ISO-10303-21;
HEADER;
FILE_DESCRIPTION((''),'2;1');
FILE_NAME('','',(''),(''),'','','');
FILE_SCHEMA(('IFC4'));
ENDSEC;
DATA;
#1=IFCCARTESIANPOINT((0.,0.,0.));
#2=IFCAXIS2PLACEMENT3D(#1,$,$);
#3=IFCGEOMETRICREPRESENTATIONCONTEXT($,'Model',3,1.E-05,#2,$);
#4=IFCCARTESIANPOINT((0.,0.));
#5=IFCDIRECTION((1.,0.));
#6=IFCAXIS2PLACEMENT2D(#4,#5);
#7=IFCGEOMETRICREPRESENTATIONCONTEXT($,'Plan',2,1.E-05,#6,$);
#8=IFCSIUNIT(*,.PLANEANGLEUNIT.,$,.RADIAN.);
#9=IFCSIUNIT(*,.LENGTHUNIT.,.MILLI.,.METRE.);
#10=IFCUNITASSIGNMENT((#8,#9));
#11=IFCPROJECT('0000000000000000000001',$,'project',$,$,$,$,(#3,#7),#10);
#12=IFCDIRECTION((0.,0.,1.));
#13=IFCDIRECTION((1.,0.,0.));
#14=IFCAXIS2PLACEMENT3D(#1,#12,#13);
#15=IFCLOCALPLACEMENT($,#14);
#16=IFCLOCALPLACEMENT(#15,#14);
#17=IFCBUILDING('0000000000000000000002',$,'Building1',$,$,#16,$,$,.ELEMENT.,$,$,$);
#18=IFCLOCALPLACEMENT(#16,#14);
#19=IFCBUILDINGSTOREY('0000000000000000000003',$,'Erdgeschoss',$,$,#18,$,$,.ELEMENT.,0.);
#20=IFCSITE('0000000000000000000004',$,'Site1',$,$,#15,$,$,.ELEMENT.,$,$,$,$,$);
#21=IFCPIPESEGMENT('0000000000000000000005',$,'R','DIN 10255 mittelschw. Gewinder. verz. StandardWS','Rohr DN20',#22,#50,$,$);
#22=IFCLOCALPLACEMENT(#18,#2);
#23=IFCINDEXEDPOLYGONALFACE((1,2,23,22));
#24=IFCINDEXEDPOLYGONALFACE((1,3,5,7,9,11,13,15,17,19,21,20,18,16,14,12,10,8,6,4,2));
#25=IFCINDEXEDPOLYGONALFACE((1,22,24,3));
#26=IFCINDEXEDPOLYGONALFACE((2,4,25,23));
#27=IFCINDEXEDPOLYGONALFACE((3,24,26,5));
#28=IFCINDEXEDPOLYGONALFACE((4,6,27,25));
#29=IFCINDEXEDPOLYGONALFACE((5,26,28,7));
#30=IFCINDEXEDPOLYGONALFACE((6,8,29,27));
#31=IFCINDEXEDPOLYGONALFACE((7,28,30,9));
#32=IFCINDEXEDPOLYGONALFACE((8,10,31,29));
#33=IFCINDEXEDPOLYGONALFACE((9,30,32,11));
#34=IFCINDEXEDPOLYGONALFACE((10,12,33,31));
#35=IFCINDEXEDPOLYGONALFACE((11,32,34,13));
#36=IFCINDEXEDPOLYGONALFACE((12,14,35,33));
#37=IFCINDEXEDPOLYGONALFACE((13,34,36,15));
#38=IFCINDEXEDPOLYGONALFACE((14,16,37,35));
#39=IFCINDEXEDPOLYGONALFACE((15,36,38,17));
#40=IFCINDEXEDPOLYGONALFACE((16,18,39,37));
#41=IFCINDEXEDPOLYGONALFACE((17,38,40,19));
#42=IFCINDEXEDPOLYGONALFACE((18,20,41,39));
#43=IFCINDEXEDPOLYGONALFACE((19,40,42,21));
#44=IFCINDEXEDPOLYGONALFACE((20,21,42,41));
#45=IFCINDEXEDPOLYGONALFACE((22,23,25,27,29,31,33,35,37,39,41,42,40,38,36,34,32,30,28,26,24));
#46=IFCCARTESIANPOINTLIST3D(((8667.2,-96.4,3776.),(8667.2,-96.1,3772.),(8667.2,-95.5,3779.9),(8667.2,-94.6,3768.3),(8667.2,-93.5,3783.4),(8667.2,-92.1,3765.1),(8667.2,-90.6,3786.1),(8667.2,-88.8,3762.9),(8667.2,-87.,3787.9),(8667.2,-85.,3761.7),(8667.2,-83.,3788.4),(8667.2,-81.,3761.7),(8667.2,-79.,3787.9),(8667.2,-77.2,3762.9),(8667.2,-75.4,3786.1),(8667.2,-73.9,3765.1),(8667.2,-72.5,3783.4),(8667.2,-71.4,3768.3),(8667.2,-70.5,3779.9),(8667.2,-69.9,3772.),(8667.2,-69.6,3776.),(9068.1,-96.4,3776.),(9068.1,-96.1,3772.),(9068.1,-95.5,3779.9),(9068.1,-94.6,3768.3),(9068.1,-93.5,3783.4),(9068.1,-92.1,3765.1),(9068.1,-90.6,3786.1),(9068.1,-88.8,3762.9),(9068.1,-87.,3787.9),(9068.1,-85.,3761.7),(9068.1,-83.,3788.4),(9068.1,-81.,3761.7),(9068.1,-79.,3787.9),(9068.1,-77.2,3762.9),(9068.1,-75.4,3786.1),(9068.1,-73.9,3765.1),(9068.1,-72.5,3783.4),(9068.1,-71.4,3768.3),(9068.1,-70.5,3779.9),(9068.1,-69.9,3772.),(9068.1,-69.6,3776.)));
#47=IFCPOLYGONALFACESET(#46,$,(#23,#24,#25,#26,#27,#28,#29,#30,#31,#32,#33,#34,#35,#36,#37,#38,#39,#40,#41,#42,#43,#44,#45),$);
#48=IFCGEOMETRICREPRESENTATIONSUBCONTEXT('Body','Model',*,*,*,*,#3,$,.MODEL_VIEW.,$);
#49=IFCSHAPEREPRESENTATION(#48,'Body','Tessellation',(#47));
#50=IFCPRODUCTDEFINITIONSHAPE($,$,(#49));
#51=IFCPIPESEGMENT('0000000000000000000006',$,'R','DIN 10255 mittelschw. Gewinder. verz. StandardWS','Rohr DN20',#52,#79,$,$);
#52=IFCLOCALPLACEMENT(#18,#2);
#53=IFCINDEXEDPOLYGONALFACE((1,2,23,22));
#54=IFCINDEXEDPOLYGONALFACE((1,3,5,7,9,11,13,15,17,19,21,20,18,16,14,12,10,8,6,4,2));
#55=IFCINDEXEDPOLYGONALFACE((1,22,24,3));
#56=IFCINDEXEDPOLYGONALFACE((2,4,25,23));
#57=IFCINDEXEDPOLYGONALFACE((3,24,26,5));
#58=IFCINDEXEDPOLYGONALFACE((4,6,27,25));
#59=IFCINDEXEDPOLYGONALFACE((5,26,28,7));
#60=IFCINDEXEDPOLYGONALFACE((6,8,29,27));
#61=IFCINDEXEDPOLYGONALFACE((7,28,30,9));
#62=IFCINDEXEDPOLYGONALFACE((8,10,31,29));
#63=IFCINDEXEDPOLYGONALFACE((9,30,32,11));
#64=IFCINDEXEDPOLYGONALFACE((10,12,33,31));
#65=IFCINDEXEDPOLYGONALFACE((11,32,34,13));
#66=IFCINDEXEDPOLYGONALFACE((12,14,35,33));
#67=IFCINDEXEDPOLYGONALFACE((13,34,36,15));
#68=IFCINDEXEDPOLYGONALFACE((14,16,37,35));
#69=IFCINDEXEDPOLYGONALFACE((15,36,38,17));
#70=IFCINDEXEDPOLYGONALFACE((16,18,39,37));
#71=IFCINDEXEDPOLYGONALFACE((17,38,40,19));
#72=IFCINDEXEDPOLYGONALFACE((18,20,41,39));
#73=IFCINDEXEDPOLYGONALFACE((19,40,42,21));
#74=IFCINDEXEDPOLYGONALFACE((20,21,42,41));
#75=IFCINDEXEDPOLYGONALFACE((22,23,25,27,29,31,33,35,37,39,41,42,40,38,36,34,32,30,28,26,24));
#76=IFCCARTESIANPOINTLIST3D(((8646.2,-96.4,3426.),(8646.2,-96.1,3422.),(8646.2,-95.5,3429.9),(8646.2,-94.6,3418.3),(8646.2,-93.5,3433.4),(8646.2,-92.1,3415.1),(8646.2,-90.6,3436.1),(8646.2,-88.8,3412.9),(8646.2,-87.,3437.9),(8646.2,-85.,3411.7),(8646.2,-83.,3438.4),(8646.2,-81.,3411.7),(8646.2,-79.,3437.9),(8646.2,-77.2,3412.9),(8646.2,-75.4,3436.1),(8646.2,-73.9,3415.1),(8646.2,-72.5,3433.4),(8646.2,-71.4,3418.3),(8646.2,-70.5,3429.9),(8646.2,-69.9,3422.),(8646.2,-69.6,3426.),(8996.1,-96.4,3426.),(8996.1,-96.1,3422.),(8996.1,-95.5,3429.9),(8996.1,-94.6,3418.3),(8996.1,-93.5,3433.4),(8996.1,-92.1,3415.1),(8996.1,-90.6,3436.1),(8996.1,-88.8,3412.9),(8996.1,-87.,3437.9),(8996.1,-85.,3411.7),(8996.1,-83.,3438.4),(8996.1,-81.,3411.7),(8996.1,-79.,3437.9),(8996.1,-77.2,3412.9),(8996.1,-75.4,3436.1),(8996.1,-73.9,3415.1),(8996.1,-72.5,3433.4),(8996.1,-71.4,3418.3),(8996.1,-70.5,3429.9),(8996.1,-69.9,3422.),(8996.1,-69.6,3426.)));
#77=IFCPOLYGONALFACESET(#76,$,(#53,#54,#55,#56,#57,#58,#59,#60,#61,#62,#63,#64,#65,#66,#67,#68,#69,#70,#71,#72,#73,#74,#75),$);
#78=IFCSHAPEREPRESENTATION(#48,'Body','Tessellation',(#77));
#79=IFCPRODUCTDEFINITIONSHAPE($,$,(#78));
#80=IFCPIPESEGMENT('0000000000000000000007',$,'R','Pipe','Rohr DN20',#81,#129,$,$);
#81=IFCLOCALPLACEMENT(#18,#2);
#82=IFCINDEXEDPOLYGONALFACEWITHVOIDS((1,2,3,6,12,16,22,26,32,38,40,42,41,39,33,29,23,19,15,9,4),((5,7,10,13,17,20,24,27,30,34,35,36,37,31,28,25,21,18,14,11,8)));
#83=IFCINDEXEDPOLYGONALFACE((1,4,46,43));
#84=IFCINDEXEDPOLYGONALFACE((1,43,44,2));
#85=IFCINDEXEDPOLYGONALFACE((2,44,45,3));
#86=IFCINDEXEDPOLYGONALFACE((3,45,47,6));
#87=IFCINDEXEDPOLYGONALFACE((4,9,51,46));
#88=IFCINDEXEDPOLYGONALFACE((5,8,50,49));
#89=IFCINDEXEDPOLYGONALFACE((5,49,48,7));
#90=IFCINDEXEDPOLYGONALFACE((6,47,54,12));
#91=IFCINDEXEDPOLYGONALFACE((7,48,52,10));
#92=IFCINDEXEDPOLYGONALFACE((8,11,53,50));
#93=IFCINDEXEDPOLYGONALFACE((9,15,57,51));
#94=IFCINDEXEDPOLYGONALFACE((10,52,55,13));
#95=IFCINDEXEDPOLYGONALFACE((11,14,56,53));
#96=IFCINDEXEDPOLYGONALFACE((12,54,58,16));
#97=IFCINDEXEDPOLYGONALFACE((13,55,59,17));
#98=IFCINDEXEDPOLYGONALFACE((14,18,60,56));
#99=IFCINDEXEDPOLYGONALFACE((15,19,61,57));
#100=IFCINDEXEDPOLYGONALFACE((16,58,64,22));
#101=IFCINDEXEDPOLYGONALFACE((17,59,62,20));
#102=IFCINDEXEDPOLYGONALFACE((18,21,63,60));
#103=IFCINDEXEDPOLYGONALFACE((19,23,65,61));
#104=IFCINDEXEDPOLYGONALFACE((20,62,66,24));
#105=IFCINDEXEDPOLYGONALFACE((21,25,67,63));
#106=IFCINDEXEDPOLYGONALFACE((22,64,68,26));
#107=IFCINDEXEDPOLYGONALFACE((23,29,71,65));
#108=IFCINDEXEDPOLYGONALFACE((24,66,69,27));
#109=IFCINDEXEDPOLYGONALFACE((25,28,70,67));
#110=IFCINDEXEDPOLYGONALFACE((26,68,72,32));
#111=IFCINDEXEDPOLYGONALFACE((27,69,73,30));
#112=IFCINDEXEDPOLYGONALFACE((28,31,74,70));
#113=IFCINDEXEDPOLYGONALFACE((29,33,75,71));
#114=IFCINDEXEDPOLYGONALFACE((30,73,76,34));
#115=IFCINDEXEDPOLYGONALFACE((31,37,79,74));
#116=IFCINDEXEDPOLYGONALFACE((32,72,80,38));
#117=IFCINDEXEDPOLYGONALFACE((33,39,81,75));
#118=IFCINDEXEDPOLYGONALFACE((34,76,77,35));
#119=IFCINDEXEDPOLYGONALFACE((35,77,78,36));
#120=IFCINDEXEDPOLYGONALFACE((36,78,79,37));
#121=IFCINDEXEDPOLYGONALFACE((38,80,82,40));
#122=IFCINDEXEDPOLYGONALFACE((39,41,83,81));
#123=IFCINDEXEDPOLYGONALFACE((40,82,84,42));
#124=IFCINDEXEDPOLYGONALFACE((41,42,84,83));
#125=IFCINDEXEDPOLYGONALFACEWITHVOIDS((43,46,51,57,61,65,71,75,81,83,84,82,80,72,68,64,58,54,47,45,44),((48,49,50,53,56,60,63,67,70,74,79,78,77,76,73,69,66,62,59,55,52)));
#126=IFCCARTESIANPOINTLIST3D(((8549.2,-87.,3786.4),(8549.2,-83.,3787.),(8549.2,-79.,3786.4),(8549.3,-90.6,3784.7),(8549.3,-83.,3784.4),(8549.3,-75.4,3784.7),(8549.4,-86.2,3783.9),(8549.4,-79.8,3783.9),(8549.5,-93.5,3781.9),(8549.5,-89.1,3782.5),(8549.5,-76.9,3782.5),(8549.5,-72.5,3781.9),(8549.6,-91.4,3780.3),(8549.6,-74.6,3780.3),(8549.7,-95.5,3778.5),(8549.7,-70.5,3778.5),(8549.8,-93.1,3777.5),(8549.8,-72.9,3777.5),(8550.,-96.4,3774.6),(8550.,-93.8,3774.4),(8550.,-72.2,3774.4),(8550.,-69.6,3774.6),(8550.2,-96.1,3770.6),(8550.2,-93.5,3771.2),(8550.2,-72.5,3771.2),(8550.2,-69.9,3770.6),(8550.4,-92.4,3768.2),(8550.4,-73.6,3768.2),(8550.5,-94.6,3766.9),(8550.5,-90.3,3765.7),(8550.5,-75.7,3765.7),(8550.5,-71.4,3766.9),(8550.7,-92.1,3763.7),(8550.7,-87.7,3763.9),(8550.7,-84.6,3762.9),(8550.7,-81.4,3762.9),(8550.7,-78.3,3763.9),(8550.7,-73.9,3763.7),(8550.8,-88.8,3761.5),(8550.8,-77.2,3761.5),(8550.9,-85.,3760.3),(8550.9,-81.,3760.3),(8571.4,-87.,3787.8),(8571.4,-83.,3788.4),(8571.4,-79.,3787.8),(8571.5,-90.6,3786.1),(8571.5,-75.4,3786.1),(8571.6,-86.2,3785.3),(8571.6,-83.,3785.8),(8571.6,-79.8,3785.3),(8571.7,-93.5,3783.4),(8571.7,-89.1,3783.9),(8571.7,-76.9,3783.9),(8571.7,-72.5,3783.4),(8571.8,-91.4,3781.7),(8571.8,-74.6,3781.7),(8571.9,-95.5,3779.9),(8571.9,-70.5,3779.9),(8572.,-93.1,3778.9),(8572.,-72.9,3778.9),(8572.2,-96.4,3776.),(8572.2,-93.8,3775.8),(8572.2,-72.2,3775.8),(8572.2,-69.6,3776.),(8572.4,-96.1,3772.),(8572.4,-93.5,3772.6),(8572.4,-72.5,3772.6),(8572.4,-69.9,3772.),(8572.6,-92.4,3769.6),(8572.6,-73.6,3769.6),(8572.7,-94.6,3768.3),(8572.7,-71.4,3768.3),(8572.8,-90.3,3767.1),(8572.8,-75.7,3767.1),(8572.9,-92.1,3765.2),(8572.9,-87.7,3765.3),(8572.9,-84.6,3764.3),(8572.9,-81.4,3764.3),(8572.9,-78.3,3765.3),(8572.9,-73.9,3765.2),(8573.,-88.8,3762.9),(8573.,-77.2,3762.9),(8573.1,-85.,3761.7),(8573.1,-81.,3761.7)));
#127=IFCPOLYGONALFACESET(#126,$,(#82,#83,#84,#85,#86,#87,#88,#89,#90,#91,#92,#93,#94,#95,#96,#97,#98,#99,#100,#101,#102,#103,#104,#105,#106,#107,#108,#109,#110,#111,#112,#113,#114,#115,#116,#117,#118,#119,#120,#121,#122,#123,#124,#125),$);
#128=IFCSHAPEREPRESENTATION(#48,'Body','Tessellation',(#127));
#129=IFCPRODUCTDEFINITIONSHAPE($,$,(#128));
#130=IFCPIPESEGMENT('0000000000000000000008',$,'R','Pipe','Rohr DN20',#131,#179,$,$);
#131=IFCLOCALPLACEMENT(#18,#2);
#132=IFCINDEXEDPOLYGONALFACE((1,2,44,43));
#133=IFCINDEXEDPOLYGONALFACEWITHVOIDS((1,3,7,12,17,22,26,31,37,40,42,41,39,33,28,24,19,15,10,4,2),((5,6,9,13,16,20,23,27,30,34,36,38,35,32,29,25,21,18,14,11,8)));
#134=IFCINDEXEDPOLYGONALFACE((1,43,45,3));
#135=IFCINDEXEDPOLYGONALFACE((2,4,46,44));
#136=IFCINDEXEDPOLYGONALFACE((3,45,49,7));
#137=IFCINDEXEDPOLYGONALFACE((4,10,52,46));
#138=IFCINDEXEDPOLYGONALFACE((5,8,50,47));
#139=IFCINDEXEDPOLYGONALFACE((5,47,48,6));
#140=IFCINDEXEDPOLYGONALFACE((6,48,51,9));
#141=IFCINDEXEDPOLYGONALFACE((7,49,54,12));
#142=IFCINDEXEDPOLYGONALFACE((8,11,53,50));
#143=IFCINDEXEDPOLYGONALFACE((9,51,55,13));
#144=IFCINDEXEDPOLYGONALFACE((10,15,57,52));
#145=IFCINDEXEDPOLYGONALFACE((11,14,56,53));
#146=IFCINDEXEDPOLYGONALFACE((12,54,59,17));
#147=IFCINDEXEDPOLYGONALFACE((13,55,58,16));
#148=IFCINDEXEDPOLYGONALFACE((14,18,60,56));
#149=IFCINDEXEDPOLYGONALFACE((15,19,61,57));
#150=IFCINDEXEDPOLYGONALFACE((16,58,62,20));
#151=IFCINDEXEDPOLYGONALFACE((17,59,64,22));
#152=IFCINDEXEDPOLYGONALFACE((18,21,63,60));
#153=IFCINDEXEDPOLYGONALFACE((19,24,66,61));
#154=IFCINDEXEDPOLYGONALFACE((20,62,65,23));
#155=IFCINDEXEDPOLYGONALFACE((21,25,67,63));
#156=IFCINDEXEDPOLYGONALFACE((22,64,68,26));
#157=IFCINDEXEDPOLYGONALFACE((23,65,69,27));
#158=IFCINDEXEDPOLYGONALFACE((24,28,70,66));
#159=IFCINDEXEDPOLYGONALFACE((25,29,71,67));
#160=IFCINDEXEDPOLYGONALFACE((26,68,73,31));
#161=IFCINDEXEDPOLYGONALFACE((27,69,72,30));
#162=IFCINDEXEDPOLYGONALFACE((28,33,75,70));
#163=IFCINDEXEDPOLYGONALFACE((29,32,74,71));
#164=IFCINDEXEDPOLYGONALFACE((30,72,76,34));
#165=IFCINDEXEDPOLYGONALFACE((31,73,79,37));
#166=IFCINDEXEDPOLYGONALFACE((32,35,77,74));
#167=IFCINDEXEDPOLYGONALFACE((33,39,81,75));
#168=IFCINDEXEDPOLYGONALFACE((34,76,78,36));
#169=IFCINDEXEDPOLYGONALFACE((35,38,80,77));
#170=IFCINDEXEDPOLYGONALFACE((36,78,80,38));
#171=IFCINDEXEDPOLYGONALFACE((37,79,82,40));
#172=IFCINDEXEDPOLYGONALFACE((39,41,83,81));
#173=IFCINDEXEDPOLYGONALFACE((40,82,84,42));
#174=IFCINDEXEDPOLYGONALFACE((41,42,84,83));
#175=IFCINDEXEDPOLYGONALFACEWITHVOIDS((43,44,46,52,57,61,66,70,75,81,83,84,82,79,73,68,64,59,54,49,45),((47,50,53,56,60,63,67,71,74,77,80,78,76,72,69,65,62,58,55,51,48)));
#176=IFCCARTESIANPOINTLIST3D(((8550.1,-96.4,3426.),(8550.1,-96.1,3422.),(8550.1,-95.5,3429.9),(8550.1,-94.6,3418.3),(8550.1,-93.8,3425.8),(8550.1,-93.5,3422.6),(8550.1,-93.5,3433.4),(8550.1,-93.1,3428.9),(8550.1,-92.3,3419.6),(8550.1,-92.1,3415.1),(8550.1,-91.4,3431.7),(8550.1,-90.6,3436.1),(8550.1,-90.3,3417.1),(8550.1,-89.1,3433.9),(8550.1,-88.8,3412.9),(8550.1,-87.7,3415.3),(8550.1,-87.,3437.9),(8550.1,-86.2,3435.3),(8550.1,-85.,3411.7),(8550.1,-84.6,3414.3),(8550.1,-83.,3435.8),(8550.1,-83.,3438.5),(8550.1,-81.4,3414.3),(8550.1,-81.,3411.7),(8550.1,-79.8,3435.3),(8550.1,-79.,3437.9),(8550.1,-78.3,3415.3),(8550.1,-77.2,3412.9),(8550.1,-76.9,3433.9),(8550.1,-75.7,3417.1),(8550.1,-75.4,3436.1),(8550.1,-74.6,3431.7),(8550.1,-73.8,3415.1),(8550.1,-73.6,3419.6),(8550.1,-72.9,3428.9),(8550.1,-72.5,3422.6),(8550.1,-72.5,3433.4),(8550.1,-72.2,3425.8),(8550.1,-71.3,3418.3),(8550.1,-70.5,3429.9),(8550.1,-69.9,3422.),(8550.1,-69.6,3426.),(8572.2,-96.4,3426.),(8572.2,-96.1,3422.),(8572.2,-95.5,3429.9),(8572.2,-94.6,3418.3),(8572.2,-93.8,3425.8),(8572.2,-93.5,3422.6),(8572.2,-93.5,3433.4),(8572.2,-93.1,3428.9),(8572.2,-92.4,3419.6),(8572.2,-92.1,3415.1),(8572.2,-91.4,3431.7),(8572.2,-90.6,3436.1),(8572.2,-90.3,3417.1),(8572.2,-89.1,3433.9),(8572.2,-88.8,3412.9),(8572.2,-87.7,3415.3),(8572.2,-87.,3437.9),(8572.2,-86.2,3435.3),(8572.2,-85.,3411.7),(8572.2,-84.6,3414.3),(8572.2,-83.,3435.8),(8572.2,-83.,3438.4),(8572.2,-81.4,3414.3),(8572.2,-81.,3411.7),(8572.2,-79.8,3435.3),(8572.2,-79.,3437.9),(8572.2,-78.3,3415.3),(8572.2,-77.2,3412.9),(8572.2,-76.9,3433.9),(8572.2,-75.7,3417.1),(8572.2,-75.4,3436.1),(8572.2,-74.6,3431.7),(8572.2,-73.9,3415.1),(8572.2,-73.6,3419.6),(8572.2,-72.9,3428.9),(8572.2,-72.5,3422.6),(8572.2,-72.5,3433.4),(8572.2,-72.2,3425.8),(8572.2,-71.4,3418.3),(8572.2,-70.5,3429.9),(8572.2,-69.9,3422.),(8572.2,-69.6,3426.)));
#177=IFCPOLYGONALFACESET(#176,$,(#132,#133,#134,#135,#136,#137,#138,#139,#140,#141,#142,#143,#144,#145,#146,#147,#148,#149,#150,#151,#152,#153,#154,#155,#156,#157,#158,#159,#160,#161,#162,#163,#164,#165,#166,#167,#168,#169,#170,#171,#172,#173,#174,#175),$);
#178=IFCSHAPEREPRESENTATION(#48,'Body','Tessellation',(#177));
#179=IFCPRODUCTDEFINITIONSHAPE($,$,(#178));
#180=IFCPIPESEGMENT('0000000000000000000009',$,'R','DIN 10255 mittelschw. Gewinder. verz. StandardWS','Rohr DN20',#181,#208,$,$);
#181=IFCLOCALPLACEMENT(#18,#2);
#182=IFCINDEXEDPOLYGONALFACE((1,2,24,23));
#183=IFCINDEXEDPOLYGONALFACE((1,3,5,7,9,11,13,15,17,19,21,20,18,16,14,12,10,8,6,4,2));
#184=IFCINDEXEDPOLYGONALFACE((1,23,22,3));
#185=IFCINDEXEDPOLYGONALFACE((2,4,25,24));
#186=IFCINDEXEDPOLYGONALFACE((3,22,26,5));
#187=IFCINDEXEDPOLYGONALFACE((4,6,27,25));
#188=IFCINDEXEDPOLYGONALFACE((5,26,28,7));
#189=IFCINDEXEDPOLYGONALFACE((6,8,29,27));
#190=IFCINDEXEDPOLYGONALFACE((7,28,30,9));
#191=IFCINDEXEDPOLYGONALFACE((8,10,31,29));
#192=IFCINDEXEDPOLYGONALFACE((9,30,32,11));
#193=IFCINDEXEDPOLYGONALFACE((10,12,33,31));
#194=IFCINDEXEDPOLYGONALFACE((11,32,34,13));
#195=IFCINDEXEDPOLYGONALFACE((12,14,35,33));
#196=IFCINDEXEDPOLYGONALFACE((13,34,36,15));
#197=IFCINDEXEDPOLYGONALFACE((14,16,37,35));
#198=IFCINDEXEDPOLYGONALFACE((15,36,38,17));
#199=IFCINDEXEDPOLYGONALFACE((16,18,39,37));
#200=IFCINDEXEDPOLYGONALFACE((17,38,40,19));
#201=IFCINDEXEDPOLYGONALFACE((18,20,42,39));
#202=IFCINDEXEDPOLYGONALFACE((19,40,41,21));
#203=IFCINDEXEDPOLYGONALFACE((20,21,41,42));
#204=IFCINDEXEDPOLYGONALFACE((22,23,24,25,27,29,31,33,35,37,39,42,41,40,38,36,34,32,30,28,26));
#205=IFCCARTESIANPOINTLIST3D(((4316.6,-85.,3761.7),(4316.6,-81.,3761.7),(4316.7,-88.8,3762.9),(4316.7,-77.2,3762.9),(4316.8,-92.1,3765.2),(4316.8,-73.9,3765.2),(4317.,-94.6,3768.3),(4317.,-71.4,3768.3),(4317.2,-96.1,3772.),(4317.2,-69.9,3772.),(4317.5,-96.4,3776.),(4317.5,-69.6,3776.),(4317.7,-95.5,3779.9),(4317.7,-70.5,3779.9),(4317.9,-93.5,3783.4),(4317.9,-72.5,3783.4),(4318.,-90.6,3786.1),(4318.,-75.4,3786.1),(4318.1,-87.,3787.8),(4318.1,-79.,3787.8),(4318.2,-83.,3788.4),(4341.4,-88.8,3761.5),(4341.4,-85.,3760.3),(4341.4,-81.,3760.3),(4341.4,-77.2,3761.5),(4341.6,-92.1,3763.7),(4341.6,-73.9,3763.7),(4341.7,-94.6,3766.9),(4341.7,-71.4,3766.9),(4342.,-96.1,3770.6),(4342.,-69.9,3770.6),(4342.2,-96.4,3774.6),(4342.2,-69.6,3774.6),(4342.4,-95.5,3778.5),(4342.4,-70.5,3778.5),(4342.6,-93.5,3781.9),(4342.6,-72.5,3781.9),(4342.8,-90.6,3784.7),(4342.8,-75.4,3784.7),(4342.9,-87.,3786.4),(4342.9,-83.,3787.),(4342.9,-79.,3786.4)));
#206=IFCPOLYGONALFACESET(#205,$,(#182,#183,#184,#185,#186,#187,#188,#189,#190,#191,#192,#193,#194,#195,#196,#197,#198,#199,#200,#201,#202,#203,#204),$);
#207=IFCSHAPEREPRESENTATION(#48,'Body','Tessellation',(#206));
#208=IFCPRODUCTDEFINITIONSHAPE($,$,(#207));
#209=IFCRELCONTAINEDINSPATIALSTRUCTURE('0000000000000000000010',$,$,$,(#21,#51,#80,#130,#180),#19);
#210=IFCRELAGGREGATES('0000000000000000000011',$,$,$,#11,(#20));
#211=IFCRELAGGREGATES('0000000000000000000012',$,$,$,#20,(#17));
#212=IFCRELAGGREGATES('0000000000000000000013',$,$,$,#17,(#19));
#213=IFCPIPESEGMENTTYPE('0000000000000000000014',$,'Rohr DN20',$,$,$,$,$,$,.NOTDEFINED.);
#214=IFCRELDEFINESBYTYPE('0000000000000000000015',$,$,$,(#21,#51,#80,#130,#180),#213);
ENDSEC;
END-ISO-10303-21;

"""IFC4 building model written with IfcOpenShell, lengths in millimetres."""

from ifc_helpers import new_model, si_unit, frame, origin, origin_with_axes, origin_2d_with_axis, place, context, subcontext, project, spatial, circle, hollow_circle, extrude, type_object, element, save


model = new_model("IFC4")

# Units and contexts
model_context = context("Model", 3, precision=1e-05, world=origin())
plan_context = context("Plan", 2, precision=1e-05, world=origin_2d_with_axis())
body_context = subcontext(model_context, "Body", "Model", "MODEL_VIEW")
ifc_project = project(units=[si_unit("PLANEANGLEUNIT", "RADIAN"), si_unit("LENGTHUNIT", "METRE", prefix="MILLI")], contexts=[model_context, plan_context])

# Site, building, storey
site_placement = place(None, origin_with_axes())
site = spatial("IfcSite", under=ifc_project, at=site_placement, Name="Site1", CompositionType="ELEMENT")
building_placement = place(site_placement, origin_with_axes())
building = spatial("IfcBuilding", under=site, at=building_placement, Name="Building1", CompositionType="ELEMENT")
storey_placement = place(building_placement, origin_with_axes())
storey = spatial("IfcBuildingStorey", under=building, at=storey_placement, Name="Erdgeschoss", CompositionType="ELEMENT", Elevation=0.0)

# Pipe segments
pipe_segment_type_1 = type_object("IfcPipeSegmentType", Name="Rohr DN20", PredefinedType="NOTDEFINED")
pipe_segment_1_placement = place(storey_placement, frame((8867.7, -83.2, 3775.0), z_axis=(0.0, 0.0, 1.0), x_axis=(1.0, 0.0, 0.0)))
element("IfcPipeSegment", 1, at=pipe_segment_1_placement, inside=storey, type_object=pipe_segment_type_1, Name="R", Description="DIN 10255 mittelschw. Gewinder. verz. StandardWS", ObjectType="Rohr DN20", context=body_context, shape_type="SolidModel", body=[
    extrude(circle(Radius=13.4, at=origin_2d_with_axis()), frame((200.5, 0.1, 0.0), z_axis=(-1.0, 0.0, 0.0), x_axis=(0.0, 0.0, 1.0)), (0.0, 0.0, 1.0), 400.9),
])
pipe_segment_2_placement = place(storey_placement, frame((8821.2, -83.2, 3425.0), z_axis=(0.0, 0.0, 1.0), x_axis=(1.0, 0.0, 0.0)))
element("IfcPipeSegment", 2, at=pipe_segment_2_placement, inside=storey, type_object=pipe_segment_type_1, Name="R", Description="DIN 10255 mittelschw. Gewinder. verz. StandardWS", ObjectType="Rohr DN20", context=body_context, shape_type="SolidModel", body=[
    extrude(circle(Radius=13.4, at=origin_2d_with_axis()), frame((175.0, 0.2, 0.0), z_axis=(-1.0, 0.0, 0.0), x_axis=(0.0, 0.0, 1.0)), (0.0, 0.0, 1.0), 349.9),
])
pipe_segment_3_placement = place(storey_placement, frame((8561.1, -82.8, 3774.3), z_axis=(0.0, 0.0, 1.0), x_axis=(1.0, 0.0, 0.0)))
element("IfcPipeSegment", 3, at=pipe_segment_3_placement, inside=storey, type_object=pipe_segment_type_1, Name="R", Description="Pipe", ObjectType="Rohr DN20", context=body_context, shape_type="SolidModel", body=[
    extrude(hollow_circle(Radius=13.4, WallThickness=2.6, at=origin_2d_with_axis()), frame((-11.1, -0.1, -0.7), z_axis=(0.99795, 0.0, 0.063994), x_axis=(0.0, 0.0, 1.0)), (0.0, 0.0, 1.0), 22.3),
])
pipe_segment_4_placement = place(storey_placement, frame((8561.2, -82.8, 3425.0), z_axis=(0.0, 0.0, 1.0), x_axis=(1.0, 0.0, 0.0)))
element("IfcPipeSegment", 4, at=pipe_segment_4_placement, inside=storey, type_object=pipe_segment_type_1, Name="R", Description="Pipe", ObjectType="Rohr DN20", context=body_context, shape_type="SolidModel", body=[
    extrude(hollow_circle(Radius=13.4, WallThickness=2.6, at=origin_2d_with_axis()), frame((-11.1, -0.1, 0.0), z_axis=(1.0, -0.000148, -0.000106), x_axis=(0.0, 0.0, 1.0)), (0.0, 0.0, 1.0), 22.2),
])
pipe_segment_5_placement = place(storey_placement, frame((4329.8, -83.2, 3774.3), z_axis=(0.0, 0.0, 1.0), x_axis=(1.0, 0.0, 0.0)))
element("IfcPipeSegment", 5, at=pipe_segment_5_placement, inside=storey, type_object=pipe_segment_type_1, Name="R", Description="DIN 10255 mittelschw. Gewinder. verz. StandardWS", ObjectType="Rohr DN20", context=body_context, shape_type="SolidModel", body=[
    extrude(circle(Radius=13.4, at=origin_2d_with_axis()), frame((12.4, 0.1, -0.7), z_axis=(-0.998345, 0.0, 0.057509), x_axis=(0.0, 0.0, 1.0)), (0.0, 0.0, 1.0), 24.8),
])

save(model, "model.ifc")
